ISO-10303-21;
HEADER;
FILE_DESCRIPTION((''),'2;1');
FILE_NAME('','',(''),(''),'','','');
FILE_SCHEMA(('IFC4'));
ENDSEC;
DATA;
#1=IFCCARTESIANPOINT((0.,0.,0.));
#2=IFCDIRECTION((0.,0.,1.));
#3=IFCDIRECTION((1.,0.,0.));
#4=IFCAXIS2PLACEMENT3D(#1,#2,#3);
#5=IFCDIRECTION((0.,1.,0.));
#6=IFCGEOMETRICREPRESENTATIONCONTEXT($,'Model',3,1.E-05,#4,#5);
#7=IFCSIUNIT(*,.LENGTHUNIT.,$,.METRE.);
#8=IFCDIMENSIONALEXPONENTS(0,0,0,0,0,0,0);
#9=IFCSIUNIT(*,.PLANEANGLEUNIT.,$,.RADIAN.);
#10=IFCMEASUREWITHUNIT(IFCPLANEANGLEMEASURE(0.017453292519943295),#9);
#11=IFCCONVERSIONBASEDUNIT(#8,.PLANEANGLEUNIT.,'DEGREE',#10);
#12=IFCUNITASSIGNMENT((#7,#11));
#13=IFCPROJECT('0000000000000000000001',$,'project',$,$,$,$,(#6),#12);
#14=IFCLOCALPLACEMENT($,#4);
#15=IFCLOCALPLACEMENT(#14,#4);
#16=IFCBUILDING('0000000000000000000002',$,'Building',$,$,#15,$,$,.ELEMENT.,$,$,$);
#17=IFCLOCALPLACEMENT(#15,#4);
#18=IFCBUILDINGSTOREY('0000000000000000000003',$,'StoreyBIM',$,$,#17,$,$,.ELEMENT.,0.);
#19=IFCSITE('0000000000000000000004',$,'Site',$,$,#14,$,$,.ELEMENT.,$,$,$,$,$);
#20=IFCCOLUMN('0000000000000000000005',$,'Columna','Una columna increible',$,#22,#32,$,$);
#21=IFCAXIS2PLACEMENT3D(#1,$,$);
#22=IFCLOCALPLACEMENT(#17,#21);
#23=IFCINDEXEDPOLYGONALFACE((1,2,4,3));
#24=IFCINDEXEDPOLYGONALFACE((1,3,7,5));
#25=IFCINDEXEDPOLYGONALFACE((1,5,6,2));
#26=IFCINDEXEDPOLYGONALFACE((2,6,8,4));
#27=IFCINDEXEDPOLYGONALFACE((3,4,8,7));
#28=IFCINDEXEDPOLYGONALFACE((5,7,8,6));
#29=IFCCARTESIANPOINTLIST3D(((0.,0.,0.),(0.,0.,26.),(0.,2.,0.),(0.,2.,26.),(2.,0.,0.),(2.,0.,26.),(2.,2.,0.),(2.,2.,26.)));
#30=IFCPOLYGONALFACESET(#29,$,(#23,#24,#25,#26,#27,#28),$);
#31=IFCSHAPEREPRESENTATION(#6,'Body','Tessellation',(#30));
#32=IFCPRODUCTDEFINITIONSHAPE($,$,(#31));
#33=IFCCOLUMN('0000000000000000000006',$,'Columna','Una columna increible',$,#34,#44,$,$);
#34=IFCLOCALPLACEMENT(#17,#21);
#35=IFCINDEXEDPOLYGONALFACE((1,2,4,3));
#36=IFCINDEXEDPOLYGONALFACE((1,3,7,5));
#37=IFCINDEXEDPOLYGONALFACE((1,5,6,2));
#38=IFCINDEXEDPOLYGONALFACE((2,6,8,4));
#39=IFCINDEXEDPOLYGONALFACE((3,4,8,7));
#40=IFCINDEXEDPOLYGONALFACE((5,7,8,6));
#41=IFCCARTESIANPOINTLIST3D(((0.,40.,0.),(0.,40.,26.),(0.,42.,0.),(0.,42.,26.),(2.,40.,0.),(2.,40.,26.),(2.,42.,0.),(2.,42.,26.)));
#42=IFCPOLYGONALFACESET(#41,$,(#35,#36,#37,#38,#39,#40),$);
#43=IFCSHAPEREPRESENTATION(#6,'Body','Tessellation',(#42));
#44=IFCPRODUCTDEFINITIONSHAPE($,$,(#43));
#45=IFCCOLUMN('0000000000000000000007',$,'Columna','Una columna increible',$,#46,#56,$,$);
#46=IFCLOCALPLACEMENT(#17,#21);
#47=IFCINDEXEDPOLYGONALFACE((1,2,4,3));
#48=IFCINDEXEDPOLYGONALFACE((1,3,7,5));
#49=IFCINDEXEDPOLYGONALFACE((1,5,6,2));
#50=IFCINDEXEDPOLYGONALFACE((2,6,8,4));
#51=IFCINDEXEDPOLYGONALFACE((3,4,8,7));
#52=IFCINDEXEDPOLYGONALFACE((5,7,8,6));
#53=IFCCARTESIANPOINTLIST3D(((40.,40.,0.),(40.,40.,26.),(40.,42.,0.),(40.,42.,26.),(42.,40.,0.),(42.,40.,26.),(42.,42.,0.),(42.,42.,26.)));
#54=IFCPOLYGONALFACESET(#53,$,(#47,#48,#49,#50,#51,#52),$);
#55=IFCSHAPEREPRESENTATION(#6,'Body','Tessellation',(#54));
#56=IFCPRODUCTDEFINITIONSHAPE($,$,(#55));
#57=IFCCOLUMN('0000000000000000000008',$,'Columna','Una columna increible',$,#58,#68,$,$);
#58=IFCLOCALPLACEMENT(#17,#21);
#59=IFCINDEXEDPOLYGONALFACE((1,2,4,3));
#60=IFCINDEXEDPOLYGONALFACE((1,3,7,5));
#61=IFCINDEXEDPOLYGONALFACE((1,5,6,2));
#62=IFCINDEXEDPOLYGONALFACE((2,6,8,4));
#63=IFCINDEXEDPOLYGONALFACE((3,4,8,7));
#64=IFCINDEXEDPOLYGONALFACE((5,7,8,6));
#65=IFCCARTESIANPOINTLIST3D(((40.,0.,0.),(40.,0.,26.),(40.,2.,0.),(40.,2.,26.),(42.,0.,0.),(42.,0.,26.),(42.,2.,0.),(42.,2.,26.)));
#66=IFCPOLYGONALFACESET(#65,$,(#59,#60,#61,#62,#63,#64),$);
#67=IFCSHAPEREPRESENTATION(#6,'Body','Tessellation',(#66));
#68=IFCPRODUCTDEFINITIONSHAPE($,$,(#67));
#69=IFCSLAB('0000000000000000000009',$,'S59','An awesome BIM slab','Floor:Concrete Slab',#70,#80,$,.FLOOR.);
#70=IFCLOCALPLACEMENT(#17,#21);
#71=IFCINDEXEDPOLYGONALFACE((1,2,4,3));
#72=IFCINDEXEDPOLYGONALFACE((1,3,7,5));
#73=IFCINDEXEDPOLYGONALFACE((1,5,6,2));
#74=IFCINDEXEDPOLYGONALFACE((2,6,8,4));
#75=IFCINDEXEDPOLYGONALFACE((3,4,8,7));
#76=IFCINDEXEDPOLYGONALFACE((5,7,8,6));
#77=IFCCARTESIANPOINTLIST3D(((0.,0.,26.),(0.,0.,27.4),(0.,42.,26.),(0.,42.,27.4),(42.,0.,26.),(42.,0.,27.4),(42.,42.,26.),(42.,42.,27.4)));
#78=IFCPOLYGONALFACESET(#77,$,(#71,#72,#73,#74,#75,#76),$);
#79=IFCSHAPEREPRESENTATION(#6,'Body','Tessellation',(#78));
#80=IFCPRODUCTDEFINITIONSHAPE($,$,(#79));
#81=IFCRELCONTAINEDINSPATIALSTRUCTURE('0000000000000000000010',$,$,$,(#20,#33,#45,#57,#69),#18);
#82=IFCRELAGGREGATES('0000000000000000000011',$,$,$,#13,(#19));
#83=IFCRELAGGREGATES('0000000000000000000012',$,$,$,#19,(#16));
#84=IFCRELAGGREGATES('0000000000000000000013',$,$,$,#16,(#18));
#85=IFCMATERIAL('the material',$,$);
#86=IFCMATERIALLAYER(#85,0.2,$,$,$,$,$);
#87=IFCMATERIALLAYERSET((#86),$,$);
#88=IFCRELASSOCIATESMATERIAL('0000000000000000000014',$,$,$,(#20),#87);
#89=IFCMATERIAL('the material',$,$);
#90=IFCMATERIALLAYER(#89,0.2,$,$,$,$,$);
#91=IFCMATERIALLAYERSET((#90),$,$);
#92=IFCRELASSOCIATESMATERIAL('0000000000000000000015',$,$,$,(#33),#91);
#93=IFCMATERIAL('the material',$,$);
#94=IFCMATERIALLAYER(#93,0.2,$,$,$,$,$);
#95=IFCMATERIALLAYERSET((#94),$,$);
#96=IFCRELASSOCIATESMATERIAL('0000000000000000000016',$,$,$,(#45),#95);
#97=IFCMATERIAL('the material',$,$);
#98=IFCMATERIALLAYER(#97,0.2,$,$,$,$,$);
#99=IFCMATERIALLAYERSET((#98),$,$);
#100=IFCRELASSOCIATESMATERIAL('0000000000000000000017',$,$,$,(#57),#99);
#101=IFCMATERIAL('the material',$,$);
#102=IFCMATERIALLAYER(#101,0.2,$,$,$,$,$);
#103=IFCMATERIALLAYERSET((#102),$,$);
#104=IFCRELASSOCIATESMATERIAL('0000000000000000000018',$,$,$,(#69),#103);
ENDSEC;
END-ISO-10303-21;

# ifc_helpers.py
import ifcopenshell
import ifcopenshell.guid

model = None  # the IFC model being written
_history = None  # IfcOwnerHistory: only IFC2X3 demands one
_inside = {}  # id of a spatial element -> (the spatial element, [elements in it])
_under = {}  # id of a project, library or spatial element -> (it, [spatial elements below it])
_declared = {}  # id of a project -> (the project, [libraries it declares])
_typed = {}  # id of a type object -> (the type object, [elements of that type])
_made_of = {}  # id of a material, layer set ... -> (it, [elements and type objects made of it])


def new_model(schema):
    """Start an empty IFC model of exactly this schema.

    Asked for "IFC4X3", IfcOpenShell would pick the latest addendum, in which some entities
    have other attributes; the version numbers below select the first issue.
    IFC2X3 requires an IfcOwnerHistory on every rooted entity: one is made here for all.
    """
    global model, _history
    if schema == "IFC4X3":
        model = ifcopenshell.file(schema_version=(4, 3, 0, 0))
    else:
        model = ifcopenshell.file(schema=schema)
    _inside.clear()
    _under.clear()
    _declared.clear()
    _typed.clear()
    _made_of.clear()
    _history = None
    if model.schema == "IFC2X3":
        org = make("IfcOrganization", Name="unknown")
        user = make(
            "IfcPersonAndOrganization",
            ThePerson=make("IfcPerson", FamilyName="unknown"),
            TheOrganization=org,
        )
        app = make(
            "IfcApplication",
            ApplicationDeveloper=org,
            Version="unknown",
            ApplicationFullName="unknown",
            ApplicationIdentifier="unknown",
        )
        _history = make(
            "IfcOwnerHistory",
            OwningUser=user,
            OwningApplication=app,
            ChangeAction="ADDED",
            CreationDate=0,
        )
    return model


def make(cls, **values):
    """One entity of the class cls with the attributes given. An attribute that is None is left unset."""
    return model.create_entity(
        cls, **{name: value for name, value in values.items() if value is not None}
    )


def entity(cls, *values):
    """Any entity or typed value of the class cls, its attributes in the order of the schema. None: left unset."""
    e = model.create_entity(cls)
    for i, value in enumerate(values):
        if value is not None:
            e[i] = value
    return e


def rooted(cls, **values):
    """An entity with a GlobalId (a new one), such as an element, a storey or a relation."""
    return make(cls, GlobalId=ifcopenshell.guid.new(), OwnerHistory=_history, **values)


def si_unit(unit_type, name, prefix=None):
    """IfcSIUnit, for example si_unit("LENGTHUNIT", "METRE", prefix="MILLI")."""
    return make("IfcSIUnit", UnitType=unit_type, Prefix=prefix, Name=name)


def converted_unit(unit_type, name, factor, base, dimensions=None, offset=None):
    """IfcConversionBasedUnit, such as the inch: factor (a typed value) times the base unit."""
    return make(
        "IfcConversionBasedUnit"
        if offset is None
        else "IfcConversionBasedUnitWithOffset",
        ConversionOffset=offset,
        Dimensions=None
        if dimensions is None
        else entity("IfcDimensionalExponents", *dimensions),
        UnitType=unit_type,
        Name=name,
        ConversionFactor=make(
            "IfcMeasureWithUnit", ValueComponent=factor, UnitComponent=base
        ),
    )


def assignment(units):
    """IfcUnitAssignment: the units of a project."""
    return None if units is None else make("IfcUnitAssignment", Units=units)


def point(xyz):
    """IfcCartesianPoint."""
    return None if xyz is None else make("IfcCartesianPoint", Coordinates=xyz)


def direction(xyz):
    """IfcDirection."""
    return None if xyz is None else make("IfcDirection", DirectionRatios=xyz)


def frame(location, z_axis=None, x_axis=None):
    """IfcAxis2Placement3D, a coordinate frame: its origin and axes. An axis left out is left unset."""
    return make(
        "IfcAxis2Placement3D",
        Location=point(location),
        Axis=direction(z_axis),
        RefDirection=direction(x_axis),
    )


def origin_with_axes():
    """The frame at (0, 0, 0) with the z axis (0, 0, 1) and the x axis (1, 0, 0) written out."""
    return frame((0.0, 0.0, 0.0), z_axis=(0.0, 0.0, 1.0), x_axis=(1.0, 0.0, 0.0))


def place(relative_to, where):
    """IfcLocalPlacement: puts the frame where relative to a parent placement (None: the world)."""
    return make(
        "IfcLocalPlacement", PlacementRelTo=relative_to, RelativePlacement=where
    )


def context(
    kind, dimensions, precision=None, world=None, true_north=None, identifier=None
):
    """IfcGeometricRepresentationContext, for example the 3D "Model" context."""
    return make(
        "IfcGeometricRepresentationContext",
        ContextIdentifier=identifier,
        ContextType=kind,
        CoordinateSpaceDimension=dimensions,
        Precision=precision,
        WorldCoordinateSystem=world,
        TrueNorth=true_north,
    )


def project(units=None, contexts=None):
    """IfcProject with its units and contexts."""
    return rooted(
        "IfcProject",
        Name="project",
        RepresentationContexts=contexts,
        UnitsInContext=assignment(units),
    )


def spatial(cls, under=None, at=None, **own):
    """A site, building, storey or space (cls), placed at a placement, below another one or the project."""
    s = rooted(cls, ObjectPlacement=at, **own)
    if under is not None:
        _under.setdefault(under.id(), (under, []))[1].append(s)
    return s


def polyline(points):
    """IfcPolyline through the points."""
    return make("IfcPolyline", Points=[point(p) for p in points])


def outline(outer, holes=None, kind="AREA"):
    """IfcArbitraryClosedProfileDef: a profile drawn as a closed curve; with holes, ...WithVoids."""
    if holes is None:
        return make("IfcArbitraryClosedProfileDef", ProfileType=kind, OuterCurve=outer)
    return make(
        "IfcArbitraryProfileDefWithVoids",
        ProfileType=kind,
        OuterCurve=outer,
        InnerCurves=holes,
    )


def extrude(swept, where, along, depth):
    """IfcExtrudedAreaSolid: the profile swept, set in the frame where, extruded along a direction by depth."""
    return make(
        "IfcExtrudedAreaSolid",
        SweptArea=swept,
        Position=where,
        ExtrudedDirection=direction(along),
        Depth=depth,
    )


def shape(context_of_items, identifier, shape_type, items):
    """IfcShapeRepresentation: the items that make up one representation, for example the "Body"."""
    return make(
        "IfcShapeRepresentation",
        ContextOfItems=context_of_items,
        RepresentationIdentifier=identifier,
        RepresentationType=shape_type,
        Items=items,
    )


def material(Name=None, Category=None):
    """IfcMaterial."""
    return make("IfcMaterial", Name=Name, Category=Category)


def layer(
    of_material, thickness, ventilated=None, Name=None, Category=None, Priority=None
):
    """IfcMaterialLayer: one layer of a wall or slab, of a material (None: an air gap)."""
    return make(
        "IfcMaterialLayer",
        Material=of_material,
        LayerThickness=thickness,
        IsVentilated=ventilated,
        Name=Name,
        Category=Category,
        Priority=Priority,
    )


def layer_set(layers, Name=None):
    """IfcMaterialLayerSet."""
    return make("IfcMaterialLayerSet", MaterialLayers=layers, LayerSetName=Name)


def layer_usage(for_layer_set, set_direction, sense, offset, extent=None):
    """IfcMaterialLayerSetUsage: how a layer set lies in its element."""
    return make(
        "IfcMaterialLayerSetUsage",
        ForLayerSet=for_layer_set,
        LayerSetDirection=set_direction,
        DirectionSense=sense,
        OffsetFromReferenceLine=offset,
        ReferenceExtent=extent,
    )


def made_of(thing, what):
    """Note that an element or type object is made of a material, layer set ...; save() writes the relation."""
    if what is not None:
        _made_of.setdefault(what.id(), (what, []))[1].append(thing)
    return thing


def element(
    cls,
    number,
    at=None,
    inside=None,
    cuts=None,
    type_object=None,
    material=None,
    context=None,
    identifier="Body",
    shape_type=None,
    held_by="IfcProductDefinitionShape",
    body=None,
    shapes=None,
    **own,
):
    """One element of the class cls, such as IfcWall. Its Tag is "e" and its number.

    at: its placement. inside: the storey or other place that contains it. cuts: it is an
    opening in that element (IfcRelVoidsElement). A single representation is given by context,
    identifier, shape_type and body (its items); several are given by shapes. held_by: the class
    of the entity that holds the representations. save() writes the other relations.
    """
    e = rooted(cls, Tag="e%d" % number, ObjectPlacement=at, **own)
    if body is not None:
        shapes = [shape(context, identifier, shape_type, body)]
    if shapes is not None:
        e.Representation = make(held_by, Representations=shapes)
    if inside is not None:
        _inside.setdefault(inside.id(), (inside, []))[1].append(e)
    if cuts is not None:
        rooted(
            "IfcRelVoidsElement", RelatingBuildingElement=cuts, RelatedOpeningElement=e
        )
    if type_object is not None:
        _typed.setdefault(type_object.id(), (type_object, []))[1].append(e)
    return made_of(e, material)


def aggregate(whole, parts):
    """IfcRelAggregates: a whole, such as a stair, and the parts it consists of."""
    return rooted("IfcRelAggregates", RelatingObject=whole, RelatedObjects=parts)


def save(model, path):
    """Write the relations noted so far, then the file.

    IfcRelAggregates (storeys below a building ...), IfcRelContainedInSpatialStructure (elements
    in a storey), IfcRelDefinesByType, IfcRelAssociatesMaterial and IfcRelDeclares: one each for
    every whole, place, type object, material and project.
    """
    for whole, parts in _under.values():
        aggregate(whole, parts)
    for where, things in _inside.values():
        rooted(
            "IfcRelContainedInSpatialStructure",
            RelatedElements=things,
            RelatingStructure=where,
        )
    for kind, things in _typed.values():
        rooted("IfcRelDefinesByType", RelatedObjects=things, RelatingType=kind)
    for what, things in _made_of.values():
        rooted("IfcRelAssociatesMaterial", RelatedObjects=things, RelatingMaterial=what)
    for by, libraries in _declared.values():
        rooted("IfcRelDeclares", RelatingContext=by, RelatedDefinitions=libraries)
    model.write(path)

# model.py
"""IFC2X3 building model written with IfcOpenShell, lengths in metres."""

from ifc_helpers import new_model, entity, si_unit, converted_unit, direction, origin_with_axes, place, context, project, spatial, polyline, outline, extrude, material, layer, layer_set, layer_usage, element, save


model = new_model("IFC2X3")

# Units and contexts
model_context = context("Model", 3, precision=1e-05, world=origin_with_axes(), true_north=direction((0.0, 1.0, 0.0)))
ifc_project = project(units=[si_unit("LENGTHUNIT", "METRE"), converted_unit("PLANEANGLEUNIT", "DEGREE", entity("IfcPlaneAngleMeasure", 0.017453292519943295), si_unit("PLANEANGLEUNIT", "RADIAN"), dimensions=[0, 0, 0, 0, 0, 0, 0])], contexts=[model_context])

# Site, building, storey
site_placement = place(None, origin_with_axes())
site = spatial("IfcSite", under=ifc_project, at=site_placement, Name="Site", CompositionType="ELEMENT")
building_placement = place(site_placement, origin_with_axes())
building = spatial("IfcBuilding", under=site, at=building_placement, Name="Building", CompositionType="ELEMENT")
storey_placement = place(building_placement, origin_with_axes())
storey = spatial("IfcBuildingStorey", under=building, at=storey_placement, Name="StoreyBIM", CompositionType="ELEMENT", Elevation=0.0)

# Columns
ifc_material_1 = material(Name="the material")
ifc_layer_1 = layer(ifc_material_1, 0.2)
ifc_layer_set_1 = layer_set([ifc_layer_1])
ifc_layer_usage_1 = layer_usage(ifc_layer_set_1, "AXIS2", "POSITIVE", -0.1)
column_1_placement = place(storey_placement, origin_with_axes())
element("IfcColumn", 1, at=column_1_placement, inside=storey, material=ifc_layer_usage_1, Name="Columna", Description="Una columna increible", context=model_context, shape_type="SweptSolid", body=[
    extrude(outline(polyline([(0.0, 0.0, 0.0), (2.0, 0.0, 0.0), (2.0, 2.0, 0.0), (0.0, 2.0, 0.0), (0.0, 0.0, 0.0)])), origin_with_axes(), (0.0, 0.0, 1.0), 26.0),
])
ifc_material_2 = material(Name="the material")
ifc_layer_2 = layer(ifc_material_2, 0.2)
ifc_layer_set_2 = layer_set([ifc_layer_2])
ifc_layer_usage_2 = layer_usage(ifc_layer_set_2, "AXIS2", "POSITIVE", -0.1)
column_2_placement = place(storey_placement, origin_with_axes())
element("IfcColumn", 2, at=column_2_placement, inside=storey, material=ifc_layer_usage_2, Name="Columna", Description="Una columna increible", context=model_context, shape_type="SweptSolid", body=[
    extrude(outline(polyline([(0.0, 40.0, 0.0), (2.0, 40.0, 0.0), (2.0, 42.0, 0.0), (0.0, 42.0, 0.0), (0.0, 40.0, 0.0)])), origin_with_axes(), (0.0, 0.0, 1.0), 26.0),
])
ifc_material_3 = material(Name="the material")
ifc_layer_3 = layer(ifc_material_3, 0.2)
ifc_layer_set_3 = layer_set([ifc_layer_3])
ifc_layer_usage_3 = layer_usage(ifc_layer_set_3, "AXIS2", "POSITIVE", -0.1)
column_3_placement = place(storey_placement, origin_with_axes())
element("IfcColumn", 3, at=column_3_placement, inside=storey, material=ifc_layer_usage_3, Name="Columna", Description="Una columna increible", context=model_context, shape_type="SweptSolid", body=[
    extrude(outline(polyline([(40.0, 40.0, 0.0), (42.0, 40.0, 0.0), (42.0, 42.0, 0.0), (40.0, 42.0, 0.0), (40.0, 40.0, 0.0)])), origin_with_axes(), (0.0, 0.0, 1.0), 26.0),
])
ifc_material_4 = material(Name="the material")
ifc_layer_4 = layer(ifc_material_4, 0.2)
ifc_layer_set_4 = layer_set([ifc_layer_4])
ifc_layer_usage_4 = layer_usage(ifc_layer_set_4, "AXIS2", "POSITIVE", -0.1)
column_4_placement = place(storey_placement, origin_with_axes())
element("IfcColumn", 4, at=column_4_placement, inside=storey, material=ifc_layer_usage_4, Name="Columna", Description="Una columna increible", context=model_context, shape_type="SweptSolid", body=[
    extrude(outline(polyline([(40.0, 0.0, 0.0), (42.0, 0.0, 0.0), (42.0, 2.0, 0.0), (40.0, 2.0, 0.0), (40.0, 0.0, 0.0)])), origin_with_axes(), (0.0, 0.0, 1.0), 26.0),
])

# Slab
ifc_material_5 = material(Name="the material")
ifc_layer_5 = layer(ifc_material_5, 0.2)
ifc_layer_set_5 = layer_set([ifc_layer_5])
ifc_layer_usage_5 = layer_usage(ifc_layer_set_5, "AXIS2", "POSITIVE", -0.1)
slab_placement = place(storey_placement, origin_with_axes())
element("IfcSlab", 5, at=slab_placement, inside=storey, material=ifc_layer_usage_5, Name="S59", Description="An awesome BIM slab", ObjectType="Floor:Concrete Slab", PredefinedType="FLOOR", context=model_context, shape_type="SweptSolid", body=[
    extrude(outline(polyline([(0.0, 0.0, 26.0), (42.0, 0.0, 26.0), (42.0, 42.0, 26.0), (0.0, 42.0, 26.0), (0.0, 0.0, 26.0)])), origin_with_axes(), (0.0, 0.0, 1.0), 1.4),
])

save(model, "model.ifc")
